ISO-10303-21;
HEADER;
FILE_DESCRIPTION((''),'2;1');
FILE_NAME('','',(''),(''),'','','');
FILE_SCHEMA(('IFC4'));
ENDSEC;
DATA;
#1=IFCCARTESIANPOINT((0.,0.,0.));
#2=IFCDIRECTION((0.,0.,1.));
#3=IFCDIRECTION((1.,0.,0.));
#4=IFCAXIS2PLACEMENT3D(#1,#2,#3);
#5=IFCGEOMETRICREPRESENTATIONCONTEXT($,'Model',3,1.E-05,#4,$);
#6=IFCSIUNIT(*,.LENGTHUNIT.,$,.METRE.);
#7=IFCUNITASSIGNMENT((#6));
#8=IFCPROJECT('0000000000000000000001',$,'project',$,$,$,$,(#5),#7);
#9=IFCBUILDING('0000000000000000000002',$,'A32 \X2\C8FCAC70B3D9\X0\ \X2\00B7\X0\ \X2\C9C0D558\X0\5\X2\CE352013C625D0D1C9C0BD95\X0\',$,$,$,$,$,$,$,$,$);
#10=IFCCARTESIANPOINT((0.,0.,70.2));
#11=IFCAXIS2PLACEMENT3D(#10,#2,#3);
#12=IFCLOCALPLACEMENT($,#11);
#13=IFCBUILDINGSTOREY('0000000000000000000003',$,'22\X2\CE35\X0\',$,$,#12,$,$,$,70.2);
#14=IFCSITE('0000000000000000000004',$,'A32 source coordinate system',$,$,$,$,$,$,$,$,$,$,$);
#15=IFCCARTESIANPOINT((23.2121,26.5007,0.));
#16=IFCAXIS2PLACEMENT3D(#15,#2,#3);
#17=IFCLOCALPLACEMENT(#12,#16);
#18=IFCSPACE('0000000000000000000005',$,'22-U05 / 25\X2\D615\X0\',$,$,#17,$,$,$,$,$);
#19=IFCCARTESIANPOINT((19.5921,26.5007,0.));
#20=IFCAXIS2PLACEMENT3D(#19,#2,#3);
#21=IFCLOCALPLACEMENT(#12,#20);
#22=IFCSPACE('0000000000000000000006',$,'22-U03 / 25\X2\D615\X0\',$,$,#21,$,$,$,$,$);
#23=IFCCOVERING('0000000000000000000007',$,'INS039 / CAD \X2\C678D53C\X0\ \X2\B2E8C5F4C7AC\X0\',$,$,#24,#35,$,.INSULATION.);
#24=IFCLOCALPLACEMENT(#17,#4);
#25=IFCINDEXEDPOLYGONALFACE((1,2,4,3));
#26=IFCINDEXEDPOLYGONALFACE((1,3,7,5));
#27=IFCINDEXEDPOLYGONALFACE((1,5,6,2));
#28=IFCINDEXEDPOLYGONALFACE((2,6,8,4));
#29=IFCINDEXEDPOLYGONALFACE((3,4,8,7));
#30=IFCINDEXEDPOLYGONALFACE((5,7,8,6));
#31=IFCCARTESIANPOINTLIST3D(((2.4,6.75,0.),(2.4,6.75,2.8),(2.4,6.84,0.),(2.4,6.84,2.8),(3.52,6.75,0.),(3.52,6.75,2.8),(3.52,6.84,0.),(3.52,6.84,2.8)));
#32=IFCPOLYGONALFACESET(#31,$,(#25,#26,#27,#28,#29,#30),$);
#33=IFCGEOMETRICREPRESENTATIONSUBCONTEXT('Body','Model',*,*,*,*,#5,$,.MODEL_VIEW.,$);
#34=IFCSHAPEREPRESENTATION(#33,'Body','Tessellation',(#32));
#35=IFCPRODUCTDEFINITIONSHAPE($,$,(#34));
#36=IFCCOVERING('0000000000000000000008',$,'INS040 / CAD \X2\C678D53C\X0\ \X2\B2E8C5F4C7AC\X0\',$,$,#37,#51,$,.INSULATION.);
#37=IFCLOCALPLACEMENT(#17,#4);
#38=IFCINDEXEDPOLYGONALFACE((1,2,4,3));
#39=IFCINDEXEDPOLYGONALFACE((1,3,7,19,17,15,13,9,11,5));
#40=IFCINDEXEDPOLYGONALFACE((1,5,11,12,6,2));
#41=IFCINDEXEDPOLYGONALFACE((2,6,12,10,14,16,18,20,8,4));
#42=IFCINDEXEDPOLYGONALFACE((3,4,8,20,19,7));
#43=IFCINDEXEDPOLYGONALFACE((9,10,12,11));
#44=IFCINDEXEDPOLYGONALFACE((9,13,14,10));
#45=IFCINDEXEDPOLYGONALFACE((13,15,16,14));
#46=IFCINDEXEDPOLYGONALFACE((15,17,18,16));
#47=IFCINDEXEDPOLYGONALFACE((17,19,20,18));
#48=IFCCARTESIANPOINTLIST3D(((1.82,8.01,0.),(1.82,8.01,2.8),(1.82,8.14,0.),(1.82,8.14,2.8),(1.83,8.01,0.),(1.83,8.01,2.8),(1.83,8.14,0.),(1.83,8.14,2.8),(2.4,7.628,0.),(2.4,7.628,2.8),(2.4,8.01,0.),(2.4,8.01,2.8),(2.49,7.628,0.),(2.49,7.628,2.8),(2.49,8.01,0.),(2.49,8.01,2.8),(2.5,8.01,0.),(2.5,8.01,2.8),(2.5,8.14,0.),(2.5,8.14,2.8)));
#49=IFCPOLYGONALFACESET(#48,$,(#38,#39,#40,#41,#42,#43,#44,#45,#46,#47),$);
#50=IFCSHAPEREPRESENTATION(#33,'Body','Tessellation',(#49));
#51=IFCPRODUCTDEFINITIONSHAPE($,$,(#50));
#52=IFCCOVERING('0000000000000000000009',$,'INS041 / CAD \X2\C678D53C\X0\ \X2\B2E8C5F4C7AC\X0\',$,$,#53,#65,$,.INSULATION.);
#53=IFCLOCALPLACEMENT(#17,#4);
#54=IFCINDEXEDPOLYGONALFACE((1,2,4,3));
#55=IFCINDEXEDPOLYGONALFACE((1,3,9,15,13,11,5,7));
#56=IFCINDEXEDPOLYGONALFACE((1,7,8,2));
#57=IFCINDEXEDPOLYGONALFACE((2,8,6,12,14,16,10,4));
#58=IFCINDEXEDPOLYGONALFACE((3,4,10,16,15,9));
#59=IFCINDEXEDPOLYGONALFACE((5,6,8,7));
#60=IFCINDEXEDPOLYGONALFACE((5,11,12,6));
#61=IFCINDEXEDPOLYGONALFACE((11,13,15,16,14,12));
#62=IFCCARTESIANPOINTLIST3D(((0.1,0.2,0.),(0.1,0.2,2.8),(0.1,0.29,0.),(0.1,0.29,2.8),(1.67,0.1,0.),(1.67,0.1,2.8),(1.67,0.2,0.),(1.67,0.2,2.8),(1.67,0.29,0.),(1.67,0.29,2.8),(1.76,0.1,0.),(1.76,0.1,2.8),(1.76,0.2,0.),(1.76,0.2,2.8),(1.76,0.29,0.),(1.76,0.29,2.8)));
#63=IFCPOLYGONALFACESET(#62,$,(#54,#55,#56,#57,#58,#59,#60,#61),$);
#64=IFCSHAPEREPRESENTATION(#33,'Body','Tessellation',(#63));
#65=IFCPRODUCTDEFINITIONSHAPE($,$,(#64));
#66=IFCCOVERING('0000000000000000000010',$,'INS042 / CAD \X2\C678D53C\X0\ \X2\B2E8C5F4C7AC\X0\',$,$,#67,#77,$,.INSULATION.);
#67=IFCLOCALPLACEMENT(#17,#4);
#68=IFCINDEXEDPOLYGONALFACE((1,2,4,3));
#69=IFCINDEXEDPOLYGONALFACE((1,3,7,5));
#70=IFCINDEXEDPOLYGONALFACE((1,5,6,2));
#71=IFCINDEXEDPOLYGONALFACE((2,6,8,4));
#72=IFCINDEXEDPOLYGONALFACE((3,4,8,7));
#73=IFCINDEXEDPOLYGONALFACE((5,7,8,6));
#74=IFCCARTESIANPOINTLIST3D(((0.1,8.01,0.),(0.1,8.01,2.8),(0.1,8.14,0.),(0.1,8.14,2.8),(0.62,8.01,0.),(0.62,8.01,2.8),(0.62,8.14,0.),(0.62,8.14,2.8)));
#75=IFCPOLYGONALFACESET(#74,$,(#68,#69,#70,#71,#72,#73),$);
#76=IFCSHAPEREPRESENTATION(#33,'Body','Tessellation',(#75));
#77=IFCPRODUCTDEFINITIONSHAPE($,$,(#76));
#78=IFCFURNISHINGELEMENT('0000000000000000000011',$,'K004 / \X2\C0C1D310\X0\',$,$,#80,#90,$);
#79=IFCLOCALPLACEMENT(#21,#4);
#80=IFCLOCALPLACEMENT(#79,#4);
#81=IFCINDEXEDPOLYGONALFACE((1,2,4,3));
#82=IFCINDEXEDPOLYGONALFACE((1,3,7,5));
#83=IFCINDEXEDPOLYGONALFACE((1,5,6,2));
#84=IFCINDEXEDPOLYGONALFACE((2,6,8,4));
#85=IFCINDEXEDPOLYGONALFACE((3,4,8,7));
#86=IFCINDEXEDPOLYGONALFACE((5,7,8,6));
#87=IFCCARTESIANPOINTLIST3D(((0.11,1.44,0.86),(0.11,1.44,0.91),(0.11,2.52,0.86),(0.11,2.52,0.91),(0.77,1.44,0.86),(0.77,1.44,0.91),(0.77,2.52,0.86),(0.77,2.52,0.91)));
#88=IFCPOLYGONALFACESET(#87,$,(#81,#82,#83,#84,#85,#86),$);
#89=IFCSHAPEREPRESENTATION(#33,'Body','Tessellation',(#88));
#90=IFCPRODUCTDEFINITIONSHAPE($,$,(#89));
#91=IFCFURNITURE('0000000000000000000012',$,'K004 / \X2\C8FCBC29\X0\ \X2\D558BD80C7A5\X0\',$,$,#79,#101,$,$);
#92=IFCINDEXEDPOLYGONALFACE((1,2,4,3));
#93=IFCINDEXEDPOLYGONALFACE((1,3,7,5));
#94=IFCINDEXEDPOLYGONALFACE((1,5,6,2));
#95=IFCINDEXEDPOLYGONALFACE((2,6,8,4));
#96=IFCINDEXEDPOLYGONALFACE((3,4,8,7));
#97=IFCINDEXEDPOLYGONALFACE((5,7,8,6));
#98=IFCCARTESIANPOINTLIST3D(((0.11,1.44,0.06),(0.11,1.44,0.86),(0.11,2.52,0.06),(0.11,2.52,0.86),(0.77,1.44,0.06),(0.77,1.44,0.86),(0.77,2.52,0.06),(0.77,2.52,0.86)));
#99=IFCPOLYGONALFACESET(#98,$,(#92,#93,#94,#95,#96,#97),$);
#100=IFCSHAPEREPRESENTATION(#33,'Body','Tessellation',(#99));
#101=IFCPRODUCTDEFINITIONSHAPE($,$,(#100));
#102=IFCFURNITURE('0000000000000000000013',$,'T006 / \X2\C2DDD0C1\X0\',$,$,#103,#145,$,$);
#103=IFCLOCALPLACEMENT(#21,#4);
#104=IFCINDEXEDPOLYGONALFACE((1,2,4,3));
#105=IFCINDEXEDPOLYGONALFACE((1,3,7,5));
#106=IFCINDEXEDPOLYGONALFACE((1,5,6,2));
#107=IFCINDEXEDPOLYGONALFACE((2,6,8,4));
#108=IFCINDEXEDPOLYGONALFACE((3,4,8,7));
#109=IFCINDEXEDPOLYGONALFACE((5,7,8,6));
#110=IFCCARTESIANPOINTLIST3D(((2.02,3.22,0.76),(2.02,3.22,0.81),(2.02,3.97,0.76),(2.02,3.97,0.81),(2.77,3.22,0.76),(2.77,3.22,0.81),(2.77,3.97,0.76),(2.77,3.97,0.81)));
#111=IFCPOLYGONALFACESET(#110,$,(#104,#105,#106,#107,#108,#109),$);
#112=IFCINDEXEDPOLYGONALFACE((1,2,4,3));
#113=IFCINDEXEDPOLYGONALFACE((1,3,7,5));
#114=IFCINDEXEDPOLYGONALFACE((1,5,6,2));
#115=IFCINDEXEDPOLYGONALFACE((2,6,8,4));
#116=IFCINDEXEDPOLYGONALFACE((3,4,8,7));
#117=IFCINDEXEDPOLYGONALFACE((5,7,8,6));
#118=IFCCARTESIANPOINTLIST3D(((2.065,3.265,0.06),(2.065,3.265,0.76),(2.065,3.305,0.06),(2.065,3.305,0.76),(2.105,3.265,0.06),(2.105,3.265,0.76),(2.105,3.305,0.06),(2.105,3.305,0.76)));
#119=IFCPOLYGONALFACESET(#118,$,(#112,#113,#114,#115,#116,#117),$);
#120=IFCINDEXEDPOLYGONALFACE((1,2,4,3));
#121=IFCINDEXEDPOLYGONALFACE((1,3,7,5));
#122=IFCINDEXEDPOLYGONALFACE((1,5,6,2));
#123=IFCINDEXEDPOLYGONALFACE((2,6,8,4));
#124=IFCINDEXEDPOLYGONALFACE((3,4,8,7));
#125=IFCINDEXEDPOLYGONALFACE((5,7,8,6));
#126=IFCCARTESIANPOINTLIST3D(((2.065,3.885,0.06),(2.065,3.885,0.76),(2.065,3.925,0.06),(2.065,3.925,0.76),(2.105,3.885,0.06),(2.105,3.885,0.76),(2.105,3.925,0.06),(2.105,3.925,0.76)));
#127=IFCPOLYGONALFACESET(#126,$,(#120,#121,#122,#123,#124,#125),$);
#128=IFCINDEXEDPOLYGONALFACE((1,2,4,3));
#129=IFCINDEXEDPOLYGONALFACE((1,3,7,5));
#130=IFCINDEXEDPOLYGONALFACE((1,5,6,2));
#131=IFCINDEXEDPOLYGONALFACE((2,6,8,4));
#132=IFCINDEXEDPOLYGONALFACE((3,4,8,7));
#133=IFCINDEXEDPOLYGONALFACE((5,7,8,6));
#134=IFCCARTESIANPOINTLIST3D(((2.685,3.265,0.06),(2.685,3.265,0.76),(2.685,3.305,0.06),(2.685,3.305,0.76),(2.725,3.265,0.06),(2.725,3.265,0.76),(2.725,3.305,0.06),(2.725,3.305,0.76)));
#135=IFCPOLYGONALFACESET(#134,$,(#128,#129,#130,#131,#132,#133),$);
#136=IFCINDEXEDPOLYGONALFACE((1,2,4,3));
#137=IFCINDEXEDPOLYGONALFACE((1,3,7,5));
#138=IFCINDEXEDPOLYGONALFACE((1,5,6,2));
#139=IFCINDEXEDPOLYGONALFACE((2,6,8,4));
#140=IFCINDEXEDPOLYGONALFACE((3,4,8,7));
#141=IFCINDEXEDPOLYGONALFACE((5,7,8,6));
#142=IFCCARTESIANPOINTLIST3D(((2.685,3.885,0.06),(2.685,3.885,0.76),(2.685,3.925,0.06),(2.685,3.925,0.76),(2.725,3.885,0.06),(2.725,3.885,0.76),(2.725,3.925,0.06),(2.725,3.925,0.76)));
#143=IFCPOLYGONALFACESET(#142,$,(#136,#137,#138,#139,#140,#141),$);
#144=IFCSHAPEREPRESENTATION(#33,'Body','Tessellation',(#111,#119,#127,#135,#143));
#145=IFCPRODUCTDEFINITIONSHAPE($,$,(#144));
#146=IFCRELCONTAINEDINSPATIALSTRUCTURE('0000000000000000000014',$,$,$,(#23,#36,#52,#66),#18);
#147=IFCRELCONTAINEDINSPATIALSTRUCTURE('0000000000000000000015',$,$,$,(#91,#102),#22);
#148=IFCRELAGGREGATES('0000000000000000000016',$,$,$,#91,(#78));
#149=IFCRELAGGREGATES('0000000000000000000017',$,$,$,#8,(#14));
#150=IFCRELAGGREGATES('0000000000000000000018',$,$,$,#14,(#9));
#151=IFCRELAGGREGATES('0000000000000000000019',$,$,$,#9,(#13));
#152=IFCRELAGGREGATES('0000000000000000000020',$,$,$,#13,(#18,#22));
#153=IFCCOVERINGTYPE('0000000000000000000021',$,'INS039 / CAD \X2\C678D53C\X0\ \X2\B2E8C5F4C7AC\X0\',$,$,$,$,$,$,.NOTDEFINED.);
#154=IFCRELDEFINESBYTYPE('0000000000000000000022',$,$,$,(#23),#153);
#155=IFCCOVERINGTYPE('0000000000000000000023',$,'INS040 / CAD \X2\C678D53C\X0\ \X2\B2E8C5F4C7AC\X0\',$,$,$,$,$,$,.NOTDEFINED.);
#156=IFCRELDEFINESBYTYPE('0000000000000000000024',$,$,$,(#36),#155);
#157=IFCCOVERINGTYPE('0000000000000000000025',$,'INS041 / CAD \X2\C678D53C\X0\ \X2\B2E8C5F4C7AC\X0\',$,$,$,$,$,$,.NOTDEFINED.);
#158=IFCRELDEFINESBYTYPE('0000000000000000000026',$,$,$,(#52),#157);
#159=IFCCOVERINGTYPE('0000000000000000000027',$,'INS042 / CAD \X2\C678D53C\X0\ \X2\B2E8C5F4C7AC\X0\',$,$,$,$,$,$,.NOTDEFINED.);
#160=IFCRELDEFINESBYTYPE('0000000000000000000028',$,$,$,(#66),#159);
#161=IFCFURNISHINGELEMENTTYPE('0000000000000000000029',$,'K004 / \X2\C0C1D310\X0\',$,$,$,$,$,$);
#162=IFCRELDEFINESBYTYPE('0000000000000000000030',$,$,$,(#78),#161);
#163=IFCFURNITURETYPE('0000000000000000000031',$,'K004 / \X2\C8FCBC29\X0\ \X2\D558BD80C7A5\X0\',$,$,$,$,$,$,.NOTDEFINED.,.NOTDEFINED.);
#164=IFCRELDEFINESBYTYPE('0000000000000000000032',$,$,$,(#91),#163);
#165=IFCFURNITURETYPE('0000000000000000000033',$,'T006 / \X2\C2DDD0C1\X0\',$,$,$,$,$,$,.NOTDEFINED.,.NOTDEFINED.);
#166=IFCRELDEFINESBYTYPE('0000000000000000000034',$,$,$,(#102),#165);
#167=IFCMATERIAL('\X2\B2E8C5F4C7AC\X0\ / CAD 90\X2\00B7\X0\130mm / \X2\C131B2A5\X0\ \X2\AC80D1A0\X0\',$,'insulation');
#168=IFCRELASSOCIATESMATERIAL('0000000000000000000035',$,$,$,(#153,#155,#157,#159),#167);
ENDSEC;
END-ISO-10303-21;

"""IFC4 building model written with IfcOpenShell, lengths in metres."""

from ifc_helpers import new_model, si_unit, frame, origin, origin_with_axes, place, context, subcontext, project, spatial, polyline, outline, extrude, source, transform, mapped, material, type_object, type_shapes, element, aggregate, save


model = new_model("IFC4")

# Units and contexts
model_context = context("Model", 3, precision=1e-05, world=origin_with_axes())
body_context = subcontext(model_context, "Body", "Model", "MODEL_VIEW")
ifc_project = project(units=[si_unit("LENGTHUNIT", "METRE")], contexts=[model_context])

# Site, building, storey, space
storey_placement = place(None, frame((0.0, 0.0, 70.2), z_axis=(0.0, 0.0, 1.0), x_axis=(1.0, 0.0, 0.0)))
space_1_placement = place(storey_placement, frame((23.2121, 26.5007, 0.0), z_axis=(0.0, 0.0, 1.0), x_axis=(1.0, 0.0, 0.0)))
site = spatial("IfcSite", under=ifc_project, Name="A32 source coordinate system")
building = spatial("IfcBuilding", under=site, Name="A32 주거동 · 지하5층–옥탑지붕")
storey = spatial("IfcBuildingStorey", under=building, at=storey_placement, Name="22층", Elevation=70.2)
space_1 = spatial("IfcSpace", under=storey, at=space_1_placement, Name="22-U05 / 25형")

# Shared definitions
space_2_placement = place(storey_placement, frame((19.5921, 26.5007, 0.0), z_axis=(0.0, 0.0, 1.0), x_axis=(1.0, 0.0, 0.0)))
space_2 = spatial("IfcSpace", under=storey, at=space_2_placement, Name="22-U03 / 25형")

# Coverings
ifc_material = material(Name="단열재 / CAD 90·130mm / 성능 검토", Category="insulation")
covering_type_1 = type_object("IfcCoveringType", Name="INS039 / CAD 외피 단열재", PredefinedType="NOTDEFINED", material=ifc_material)
shared_shape_1 = source(origin(), body_context, "Body", "SweptSolid", [
    extrude(outline(polyline([(2.4, 6.75), (2.4, 6.84), (3.52, 6.84), (3.52, 6.75), (2.4, 6.75)])), origin(), (0.0, 0.0, 1.0), 2.8),
])
type_shapes(covering_type_1, [shared_shape_1])
covering_1_placement = place(space_1_placement, origin_with_axes())
element("IfcCovering", 1, at=covering_1_placement, inside=space_1, type_object=covering_type_1, Name="INS039 / CAD 외피 단열재", PredefinedType="INSULATION", context=body_context, shape_type="MappedRepresentation", body=[
    mapped(shared_shape_1, transform((0.0, 0.0, 0.0), scale=1.0)),
])
covering_type_2 = type_object("IfcCoveringType", Name="INS040 / CAD 외피 단열재", PredefinedType="NOTDEFINED", material=ifc_material)
shared_shape_2 = source(origin(), body_context, "Body", "SweptSolid", [
    extrude(outline(polyline([(2.4, 7.628), (2.4, 8.01), (1.83, 8.01), (1.82, 8.01), (1.82, 8.14), (1.83, 8.14), (2.5, 8.14), (2.5, 8.01), (2.49, 8.01), (2.49, 7.628), (2.4, 7.628)])), origin(), (0.0, 0.0, 1.0), 2.8),
])
type_shapes(covering_type_2, [shared_shape_2])
covering_2_placement = place(space_1_placement, origin_with_axes())
element("IfcCovering", 2, at=covering_2_placement, inside=space_1, type_object=covering_type_2, Name="INS040 / CAD 외피 단열재", PredefinedType="INSULATION", context=body_context, shape_type="MappedRepresentation", body=[
    mapped(shared_shape_2, transform((0.0, 0.0, 0.0), scale=1.0)),
])
covering_type_3 = type_object("IfcCoveringType", Name="INS041 / CAD 외피 단열재", PredefinedType="NOTDEFINED", material=ifc_material)
shared_shape_3 = source(origin(), body_context, "Body", "SweptSolid", [
    extrude(outline(polyline([(1.67, 0.2), (0.1, 0.2), (0.1, 0.29), (1.67, 0.29), (1.76, 0.29), (1.76, 0.2), (1.76, 0.1), (1.67, 0.1), (1.67, 0.2)])), origin(), (0.0, 0.0, 1.0), 2.8),
])
type_shapes(covering_type_3, [shared_shape_3])
covering_3_placement = place(space_1_placement, origin_with_axes())
element("IfcCovering", 3, at=covering_3_placement, inside=space_1, type_object=covering_type_3, Name="INS041 / CAD 외피 단열재", PredefinedType="INSULATION", context=body_context, shape_type="MappedRepresentation", body=[
    mapped(shared_shape_3, transform((0.0, 0.0, 0.0), scale=1.0)),
])
covering_type_4 = type_object("IfcCoveringType", Name="INS042 / CAD 외피 단열재", PredefinedType="NOTDEFINED", material=ifc_material)
shared_shape_4 = source(origin(), body_context, "Body", "SweptSolid", [
    extrude(outline(polyline([(0.62, 8.14), (0.62, 8.01), (0.1, 8.01), (0.1, 8.14), (0.62, 8.14)])), origin(), (0.0, 0.0, 1.0), 2.8),
])
type_shapes(covering_type_4, [shared_shape_4])
covering_4_placement = place(space_1_placement, origin_with_axes())
element("IfcCovering", 4, at=covering_4_placement, inside=space_1, type_object=covering_type_4, Name="INS042 / CAD 외피 단열재", PredefinedType="INSULATION", context=body_context, shape_type="MappedRepresentation", body=[
    mapped(shared_shape_4, transform((0.0, 0.0, 0.0), scale=1.0)),
])

# Furnishing element
furnishing_element_type_1 = type_object("IfcFurnishingElementType", Name="K004 / 상판")
shared_shape_5 = source(origin(), body_context, "Body", "SweptSolid", [
    extrude(outline(polyline([(0.77, 2.52), (0.77, 1.44), (0.11, 1.44), (0.11, 2.52), (0.77, 2.52)])), frame((0.0, 0.0, 0.86)), (0.0, 0.0, 1.0), 0.05),
])
type_shapes(furnishing_element_type_1, [shared_shape_5])
furniture_1_placement = place(space_2_placement, origin_with_axes())
furnishing_1_placement = place(furniture_1_placement, origin_with_axes())
furnishing_1 = element("IfcFurnishingElement", 5, at=furnishing_1_placement, type_object=furnishing_element_type_1, Name="K004 / 상판", context=body_context, shape_type="MappedRepresentation", body=[
    mapped(shared_shape_5, transform((0.0, 0.0, 0.0), scale=1.0)),
])

# Furniture
furniture_type_1 = type_object("IfcFurnitureType", Name="K004 / 주방 하부장", AssemblyPlace="NOTDEFINED", PredefinedType="NOTDEFINED")
shared_shape_6 = source(origin(), body_context, "Body", "SweptSolid", [
    extrude(outline(polyline([(0.11, 2.52), (0.77, 2.52), (0.77, 1.44), (0.11, 1.44), (0.11, 2.52)])), frame((0.0, 0.0, 0.06)), (0.0, 0.0, 1.0), 0.8),
])
type_shapes(furniture_type_1, [shared_shape_6])
furniture_1 = element("IfcFurniture", 6, at=furniture_1_placement, inside=space_2, type_object=furniture_type_1, Name="K004 / 주방 하부장", context=body_context, shape_type="MappedRepresentation", body=[
    mapped(shared_shape_6, transform((0.0, 0.0, 0.0), scale=1.0)),
])
aggregate(furniture_1, [furnishing_1])
furniture_type_2 = type_object("IfcFurnitureType", Name="T006 / 식탁", AssemblyPlace="NOTDEFINED", PredefinedType="NOTDEFINED")
shared_shape_7 = source(origin(), body_context, "Body", "SweptSolid", [
    extrude(outline(polyline([(2.77, 3.22), (2.02, 3.22), (2.02, 3.97), (2.77, 3.97), (2.77, 3.22)])), frame((0.0, 0.0, 0.76)), (0.0, 0.0, 1.0), 0.05),
    extrude(outline(polyline([(2.065, 3.265), (2.065, 3.305), (2.105, 3.305), (2.105, 3.265), (2.065, 3.265)])), frame((0.0, 0.0, 0.06)), (0.0, 0.0, 1.0), 0.7),
    extrude(outline(polyline([(2.065, 3.885), (2.065, 3.925), (2.105, 3.925), (2.105, 3.885), (2.065, 3.885)])), frame((0.0, 0.0, 0.06)), (0.0, 0.0, 1.0), 0.7),
    extrude(outline(polyline([(2.685, 3.265), (2.685, 3.305), (2.725, 3.305), (2.725, 3.265), (2.685, 3.265)])), frame((0.0, 0.0, 0.06)), (0.0, 0.0, 1.0), 0.7),
    extrude(outline(polyline([(2.685, 3.885), (2.685, 3.925), (2.725, 3.925), (2.725, 3.885), (2.685, 3.885)])), frame((0.0, 0.0, 0.06)), (0.0, 0.0, 1.0), 0.7),
])
type_shapes(furniture_type_2, [shared_shape_7])
furniture_2_placement = place(space_2_placement, origin_with_axes())
element("IfcFurniture", 7, at=furniture_2_placement, inside=space_2, type_object=furniture_type_2, Name="T006 / 식탁", context=body_context, shape_type="MappedRepresentation", body=[
    mapped(shared_shape_7, transform((0.0, 0.0, 0.0), scale=1.0)),
])

save(model, "model.ifc")
